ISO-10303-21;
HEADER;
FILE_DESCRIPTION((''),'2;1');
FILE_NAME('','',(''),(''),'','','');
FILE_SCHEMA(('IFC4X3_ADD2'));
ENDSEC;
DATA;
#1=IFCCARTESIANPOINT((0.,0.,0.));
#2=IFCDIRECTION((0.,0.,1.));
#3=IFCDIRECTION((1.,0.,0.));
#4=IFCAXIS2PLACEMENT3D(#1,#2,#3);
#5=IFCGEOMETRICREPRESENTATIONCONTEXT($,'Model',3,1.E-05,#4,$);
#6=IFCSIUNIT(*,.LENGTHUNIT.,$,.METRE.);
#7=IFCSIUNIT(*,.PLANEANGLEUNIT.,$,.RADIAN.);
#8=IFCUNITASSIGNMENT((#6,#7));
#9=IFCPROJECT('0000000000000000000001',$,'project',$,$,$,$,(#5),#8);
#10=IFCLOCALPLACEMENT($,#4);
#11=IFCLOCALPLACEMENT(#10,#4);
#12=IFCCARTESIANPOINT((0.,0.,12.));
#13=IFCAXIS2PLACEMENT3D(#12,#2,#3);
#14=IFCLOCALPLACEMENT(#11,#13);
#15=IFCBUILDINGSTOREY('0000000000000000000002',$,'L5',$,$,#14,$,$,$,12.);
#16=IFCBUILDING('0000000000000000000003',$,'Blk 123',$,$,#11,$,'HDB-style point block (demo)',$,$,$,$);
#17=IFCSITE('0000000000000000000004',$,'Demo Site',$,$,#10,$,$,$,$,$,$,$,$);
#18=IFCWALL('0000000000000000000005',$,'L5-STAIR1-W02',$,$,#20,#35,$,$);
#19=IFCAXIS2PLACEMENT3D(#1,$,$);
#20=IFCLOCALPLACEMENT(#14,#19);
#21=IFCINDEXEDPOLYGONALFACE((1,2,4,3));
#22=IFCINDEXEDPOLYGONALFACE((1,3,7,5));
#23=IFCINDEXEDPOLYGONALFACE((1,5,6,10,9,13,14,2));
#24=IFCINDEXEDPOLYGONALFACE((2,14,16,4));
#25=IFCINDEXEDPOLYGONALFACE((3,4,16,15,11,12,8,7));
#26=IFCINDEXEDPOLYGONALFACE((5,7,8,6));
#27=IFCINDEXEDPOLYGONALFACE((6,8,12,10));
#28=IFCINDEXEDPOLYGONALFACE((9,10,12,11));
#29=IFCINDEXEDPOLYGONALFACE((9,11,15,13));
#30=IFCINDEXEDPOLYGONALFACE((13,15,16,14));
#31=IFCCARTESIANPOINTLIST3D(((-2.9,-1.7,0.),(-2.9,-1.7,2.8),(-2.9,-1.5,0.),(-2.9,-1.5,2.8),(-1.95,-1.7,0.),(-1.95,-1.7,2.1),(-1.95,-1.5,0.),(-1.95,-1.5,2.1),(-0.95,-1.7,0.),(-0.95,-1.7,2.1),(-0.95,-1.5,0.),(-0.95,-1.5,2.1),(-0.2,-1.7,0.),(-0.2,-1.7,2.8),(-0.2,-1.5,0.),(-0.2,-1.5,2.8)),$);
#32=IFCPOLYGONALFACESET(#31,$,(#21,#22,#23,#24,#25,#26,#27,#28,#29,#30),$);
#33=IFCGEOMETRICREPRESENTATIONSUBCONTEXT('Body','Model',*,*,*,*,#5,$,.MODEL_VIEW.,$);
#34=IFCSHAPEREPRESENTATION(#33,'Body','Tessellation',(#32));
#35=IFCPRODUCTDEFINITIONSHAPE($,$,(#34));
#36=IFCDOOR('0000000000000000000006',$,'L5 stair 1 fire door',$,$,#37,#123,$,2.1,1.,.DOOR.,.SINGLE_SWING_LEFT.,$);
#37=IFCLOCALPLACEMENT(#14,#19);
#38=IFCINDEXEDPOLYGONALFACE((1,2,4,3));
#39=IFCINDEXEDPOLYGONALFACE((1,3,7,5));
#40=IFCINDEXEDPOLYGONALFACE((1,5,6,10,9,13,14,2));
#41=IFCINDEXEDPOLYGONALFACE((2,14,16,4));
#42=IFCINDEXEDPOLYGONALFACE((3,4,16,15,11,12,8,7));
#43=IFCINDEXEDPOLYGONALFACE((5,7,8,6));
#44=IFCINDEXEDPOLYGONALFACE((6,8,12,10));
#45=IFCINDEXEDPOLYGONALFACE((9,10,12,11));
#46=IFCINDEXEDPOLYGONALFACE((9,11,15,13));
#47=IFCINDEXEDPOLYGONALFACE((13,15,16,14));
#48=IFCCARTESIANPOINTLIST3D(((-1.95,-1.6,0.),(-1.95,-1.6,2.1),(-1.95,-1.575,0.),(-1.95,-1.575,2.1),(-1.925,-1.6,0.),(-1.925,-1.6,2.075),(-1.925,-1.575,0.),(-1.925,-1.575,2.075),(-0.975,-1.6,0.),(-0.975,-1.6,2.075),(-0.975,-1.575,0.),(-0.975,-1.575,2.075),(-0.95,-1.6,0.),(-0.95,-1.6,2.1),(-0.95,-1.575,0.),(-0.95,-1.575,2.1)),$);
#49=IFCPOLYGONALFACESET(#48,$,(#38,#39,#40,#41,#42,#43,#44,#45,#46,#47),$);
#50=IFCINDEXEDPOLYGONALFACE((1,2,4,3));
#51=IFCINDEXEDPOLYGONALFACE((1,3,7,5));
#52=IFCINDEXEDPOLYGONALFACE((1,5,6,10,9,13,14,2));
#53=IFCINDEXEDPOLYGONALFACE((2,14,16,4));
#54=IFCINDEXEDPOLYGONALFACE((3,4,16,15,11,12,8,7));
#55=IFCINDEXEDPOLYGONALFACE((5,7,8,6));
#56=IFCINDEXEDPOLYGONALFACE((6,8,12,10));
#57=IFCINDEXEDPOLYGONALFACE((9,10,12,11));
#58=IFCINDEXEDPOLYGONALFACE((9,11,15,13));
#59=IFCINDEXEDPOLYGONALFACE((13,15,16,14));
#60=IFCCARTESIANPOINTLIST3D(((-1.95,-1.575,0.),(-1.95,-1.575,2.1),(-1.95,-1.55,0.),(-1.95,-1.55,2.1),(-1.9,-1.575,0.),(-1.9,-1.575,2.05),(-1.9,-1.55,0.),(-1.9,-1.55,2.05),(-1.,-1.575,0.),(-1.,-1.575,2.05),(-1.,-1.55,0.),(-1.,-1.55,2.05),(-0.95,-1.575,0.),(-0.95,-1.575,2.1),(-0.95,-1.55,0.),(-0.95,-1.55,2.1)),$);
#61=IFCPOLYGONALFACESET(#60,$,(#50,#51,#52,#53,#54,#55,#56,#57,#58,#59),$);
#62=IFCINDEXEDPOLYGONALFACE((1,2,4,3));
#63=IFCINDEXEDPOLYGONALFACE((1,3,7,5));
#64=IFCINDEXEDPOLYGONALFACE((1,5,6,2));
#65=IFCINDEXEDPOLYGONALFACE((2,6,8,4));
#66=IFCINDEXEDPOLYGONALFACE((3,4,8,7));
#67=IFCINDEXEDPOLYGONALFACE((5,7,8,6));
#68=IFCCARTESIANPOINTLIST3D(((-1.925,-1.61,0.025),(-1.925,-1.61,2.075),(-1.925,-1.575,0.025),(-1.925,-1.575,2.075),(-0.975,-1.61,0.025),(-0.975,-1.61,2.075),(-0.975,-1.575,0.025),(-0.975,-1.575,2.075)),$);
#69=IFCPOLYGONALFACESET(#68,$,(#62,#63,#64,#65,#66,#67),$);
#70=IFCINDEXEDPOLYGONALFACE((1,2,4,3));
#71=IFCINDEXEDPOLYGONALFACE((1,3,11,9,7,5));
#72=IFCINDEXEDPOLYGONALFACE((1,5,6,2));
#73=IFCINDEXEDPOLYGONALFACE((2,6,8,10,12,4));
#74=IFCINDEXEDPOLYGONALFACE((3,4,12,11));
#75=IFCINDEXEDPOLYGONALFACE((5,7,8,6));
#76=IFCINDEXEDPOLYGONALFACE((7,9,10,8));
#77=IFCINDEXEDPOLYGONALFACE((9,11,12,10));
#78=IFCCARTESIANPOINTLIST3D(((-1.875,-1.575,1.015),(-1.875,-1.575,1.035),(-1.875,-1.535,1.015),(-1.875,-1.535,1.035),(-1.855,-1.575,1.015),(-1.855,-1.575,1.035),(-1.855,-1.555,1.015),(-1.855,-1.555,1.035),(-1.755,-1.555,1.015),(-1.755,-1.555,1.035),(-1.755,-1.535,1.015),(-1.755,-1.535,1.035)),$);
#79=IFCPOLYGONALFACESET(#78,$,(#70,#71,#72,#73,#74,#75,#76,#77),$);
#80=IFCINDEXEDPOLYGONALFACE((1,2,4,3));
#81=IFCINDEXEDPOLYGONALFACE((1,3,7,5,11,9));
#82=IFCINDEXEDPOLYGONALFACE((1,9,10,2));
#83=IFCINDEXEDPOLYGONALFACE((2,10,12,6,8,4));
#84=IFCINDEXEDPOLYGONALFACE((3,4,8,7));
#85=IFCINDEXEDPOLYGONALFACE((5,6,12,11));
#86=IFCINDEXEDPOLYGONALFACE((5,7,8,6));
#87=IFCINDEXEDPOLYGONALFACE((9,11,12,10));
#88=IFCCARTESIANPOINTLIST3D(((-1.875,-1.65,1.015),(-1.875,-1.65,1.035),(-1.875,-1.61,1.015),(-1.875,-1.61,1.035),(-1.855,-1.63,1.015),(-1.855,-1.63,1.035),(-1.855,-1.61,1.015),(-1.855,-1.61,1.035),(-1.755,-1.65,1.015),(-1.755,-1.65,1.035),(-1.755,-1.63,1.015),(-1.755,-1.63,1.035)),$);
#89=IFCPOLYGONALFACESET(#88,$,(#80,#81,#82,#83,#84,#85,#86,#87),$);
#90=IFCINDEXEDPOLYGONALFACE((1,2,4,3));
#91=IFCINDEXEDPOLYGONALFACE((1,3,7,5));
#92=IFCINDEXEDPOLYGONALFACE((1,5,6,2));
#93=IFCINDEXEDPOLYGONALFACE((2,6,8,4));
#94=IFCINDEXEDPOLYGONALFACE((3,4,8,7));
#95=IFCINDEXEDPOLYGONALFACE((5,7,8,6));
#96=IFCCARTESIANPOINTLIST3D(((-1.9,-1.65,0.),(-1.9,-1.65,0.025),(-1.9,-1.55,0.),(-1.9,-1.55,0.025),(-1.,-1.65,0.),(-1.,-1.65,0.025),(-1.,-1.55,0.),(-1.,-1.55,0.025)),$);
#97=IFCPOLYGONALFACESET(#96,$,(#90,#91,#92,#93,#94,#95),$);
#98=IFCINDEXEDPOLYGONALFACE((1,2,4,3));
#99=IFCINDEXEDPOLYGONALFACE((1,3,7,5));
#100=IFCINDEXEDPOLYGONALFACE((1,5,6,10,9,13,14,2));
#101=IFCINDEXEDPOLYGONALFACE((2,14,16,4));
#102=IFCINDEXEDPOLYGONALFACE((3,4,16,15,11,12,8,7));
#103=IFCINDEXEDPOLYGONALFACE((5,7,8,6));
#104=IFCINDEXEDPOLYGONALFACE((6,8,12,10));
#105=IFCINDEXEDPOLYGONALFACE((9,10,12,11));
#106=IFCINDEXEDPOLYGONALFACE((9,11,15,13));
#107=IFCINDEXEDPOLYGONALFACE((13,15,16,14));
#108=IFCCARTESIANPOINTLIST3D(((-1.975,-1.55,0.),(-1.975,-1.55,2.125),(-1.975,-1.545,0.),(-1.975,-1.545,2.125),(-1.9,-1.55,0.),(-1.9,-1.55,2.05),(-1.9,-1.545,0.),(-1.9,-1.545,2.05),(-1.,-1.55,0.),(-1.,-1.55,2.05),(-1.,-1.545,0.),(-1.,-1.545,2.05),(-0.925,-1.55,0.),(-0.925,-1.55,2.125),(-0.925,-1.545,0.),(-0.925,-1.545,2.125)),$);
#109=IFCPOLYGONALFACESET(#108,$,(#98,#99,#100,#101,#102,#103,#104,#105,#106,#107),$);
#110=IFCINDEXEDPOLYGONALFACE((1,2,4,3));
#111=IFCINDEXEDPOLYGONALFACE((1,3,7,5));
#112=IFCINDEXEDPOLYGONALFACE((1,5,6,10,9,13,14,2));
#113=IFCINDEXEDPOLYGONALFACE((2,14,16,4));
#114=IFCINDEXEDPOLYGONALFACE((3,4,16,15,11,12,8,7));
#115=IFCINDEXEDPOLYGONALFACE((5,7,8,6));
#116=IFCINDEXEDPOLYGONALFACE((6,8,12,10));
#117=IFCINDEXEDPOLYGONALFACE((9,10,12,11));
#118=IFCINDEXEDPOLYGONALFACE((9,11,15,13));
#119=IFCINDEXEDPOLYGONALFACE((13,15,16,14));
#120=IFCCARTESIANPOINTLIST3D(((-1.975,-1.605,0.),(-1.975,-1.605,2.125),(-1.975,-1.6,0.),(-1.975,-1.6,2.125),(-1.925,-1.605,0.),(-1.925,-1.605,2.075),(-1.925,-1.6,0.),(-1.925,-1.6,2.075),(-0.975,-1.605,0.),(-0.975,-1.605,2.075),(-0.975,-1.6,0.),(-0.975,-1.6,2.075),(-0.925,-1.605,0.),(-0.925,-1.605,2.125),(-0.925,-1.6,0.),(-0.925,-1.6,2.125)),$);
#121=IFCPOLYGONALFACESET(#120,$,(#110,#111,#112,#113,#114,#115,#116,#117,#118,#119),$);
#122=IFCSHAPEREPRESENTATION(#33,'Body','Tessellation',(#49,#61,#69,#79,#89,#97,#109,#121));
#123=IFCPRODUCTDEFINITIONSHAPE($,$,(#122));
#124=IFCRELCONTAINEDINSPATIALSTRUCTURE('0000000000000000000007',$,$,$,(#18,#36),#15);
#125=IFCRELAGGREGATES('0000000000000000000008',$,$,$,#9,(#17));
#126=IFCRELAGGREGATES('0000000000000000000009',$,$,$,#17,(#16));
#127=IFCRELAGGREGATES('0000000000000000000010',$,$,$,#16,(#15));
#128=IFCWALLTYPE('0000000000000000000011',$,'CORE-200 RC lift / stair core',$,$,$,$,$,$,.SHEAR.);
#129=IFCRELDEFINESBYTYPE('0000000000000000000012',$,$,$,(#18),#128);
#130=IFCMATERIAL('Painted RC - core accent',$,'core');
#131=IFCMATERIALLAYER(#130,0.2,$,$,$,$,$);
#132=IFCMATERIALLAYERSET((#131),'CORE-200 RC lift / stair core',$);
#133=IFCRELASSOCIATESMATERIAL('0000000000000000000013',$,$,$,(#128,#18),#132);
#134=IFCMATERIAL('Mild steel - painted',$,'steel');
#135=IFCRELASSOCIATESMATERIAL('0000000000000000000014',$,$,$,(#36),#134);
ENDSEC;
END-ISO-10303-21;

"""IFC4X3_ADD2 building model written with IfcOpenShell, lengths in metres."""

from ifc_helpers import new_model, si_unit, frame, origin_with_axes, place, context, subcontext, project, spatial, line, indexed_curve, outline, extrude, material, layer, layer_set, layer_usage, type_object, element, fill, save


model = new_model("IFC4X3_ADD2")

# Units and contexts
model_context = context("Model", 3, precision=1e-05, world=origin_with_axes())
body_context = subcontext(model_context, "Body", "Model", "MODEL_VIEW")
ifc_project = project(units=[si_unit("LENGTHUNIT", "METRE"), si_unit("PLANEANGLEUNIT", "RADIAN")], contexts=[model_context])

# Site, building, storey
site_placement = place(None, origin_with_axes())
site = spatial("IfcSite", under=ifc_project, at=site_placement, Name="Demo Site")
building_placement = place(site_placement, origin_with_axes())
building = spatial("IfcBuilding", under=site, at=building_placement, Name="Blk 123", LongName="HDB-style point block (demo)")
storey_placement = place(building_placement, frame((0.0, 0.0, 12.0), z_axis=(0.0, 0.0, 1.0), x_axis=(1.0, 0.0, 0.0)))
storey = spatial("IfcBuildingStorey", under=building, at=storey_placement, Name="L5", Elevation=12.0)

# Shared definitions
ifc_material_1 = material(Name="Painted RC - core accent", Category="core")
ifc_layer_1 = layer(ifc_material_1, 0.2)
ifc_layer_set_1 = layer_set([ifc_layer_1], Name="CORE-200 RC lift / stair core")
ifc_layer_usage_1 = layer_usage(ifc_layer_set_1, "AXIS2", "POSITIVE", 0.0)
wall_type_1 = type_object("IfcWallType", Name="CORE-200 RC lift / stair core", PredefinedType="SHEAR", material=ifc_layer_set_1)

# Wall, opening, door
wall_1_placement = place(storey_placement, frame((-0.2, -1.5, 0.0), z_axis=(0.0, 0.0, 1.0), x_axis=(-1.0, 0.0, 0.0)))
wall_1 = element("IfcWall", 1, at=wall_1_placement, inside=storey, type_object=wall_type_1, material=ifc_layer_usage_1, Name="L5-STAIR1-W02", context=body_context, shape_type="SweptSolid", body=[
    extrude(outline(indexed_curve([(0.0, 0.0), (0.0, 0.2), (2.7, 0.2), (2.7, 0.0), (0.0, 0.0)], self_intersect=False)), origin_with_axes(), (0.0, 0.0, 1.0), 2.8),
])
opening_1_placement = place(wall_1_placement, frame((0.75, -0.1, 0.0), z_axis=(0.0, 0.0, 1.0), x_axis=(1.0, 0.0, 0.0)))
opening_1 = element("IfcOpeningElement", 2, at=opening_1_placement, cuts=wall_1, context=body_context, shape_type="SweptSolid", body=[
    extrude(outline(indexed_curve([(0.0, 0.0), (0.0, 0.4), (1.0, 0.4), (1.0, 0.0), (0.0, 0.0)], self_intersect=False)), origin_with_axes(), (0.0, 0.0, 1.0), 2.1),
])
ifc_material_2 = material(Name="Mild steel - painted", Category="steel")
door_1_placement = place(opening_1_placement, frame((0.0, 0.15, 0.0), z_axis=(0.0, 0.0, 1.0), x_axis=(1.0, 0.0, 0.0)))
door_1 = element("IfcDoor", 3, at=door_1_placement, inside=storey, material=ifc_material_2, Name="L5 stair 1 fire door", OperationType="SINGLE_SWING_LEFT", OverallHeight=2.1, OverallWidth=1.0, PredefinedType="DOOR", context=body_context, shape_type="SweptSolid", body=[
    extrude(outline(indexed_curve([(0.0, 0.0), (0.0, 2.1), (1.0, 2.1), (1.0, 0.0), (0.975, 0.0), (0.975, 2.075), (0.025, 2.075), (0.025, 0.0)], segments=[line(1, 2, 3, 4, 5, 6, 7, 8, 1)])), frame((0.0, 0.025, 0.0), z_axis=(0.0, -1.0, 0.0), x_axis=(1.0, 0.0, 0.0)), (0.0, 0.0, -1.0), 0.025),
    extrude(outline(indexed_curve([(0.0, 0.0), (0.0, 2.1), (1.0, 2.1), (1.0, 0.0), (0.95, 0.0), (0.95, 2.05), (0.05, 2.05), (0.05, 0.0)], segments=[line(1, 2, 3, 4, 5, 6, 7, 8, 1)])), frame((0.0, 0.0, 0.0), z_axis=(0.0, -1.0, 0.0), x_axis=(1.0, 0.0, 0.0)), (0.0, 0.0, -1.0), 0.025),
    extrude(outline(indexed_curve([(0.0, 0.0), (0.95, 0.0), (0.95, 0.035), (0.0, 0.035)], segments=[line(1, 2, 3, 4, 1)])), frame((0.025, 0.025, 0.025), z_axis=(0.0, 0.0, 1.0), x_axis=(1.0, 0.0, 0.0)), (0.0, 0.0, 1.0), 2.05),
    extrude(outline(indexed_curve([(0.0, 0.0), (0.0, -0.04), (-0.12, -0.04), (-0.12, -0.02), (-0.02, -0.02), (-0.02, 0.0)], segments=[line(1, 2, 3, 4, 5, 6, 1)])), frame((0.925, 0.025, 1.015), z_axis=(0.0, 0.0, 1.0), x_axis=(1.0, 0.0, 0.0)), (0.0, 0.0, 1.0), 0.02),
    extrude(outline(indexed_curve([(0.0, 0.0), (0.0, 0.04), (-0.12, 0.04), (-0.12, 0.02), (-0.02, 0.02), (-0.02, 0.0)], segments=[line(1, 2, 3, 4, 5, 6, 1)])), frame((0.925, 0.06, 1.015), z_axis=(0.0, 0.0, 1.0), x_axis=(1.0, 0.0, 0.0)), (0.0, 0.0, 1.0), 0.02),
    extrude(outline(indexed_curve([(0.0, 0.0), (0.9, 0.0), (0.9, 0.1), (0.0, 0.1)], segments=[line(1, 2, 3, 4, 1)])), frame((0.05, 0.0, 0.0), z_axis=(0.0, 0.0, 1.0), x_axis=(1.0, 0.0, 0.0)), (0.0, 0.0, 1.0), 0.025),
    extrude(outline(indexed_curve([(0.0, 0.0), (0.0, 2.125), (1.05, 2.125), (1.05, 0.0), (0.975, 0.0), (0.975, 2.05), (0.075, 2.05), (0.075, 0.0)], segments=[line(1, 2, 3, 4, 5, 6, 7, 8, 1)])), frame((-0.025, -0.005, 0.0), z_axis=(0.0, -1.0, 0.0), x_axis=(1.0, 0.0, 0.0)), (0.0, 0.0, -1.0), 0.005),
    extrude(outline(indexed_curve([(0.0, 0.0), (0.0, 2.125), (1.05, 2.125), (1.05, 0.0), (1.0, 0.0), (1.0, 2.075), (0.05, 2.075), (0.05, 0.0)], segments=[line(1, 2, 3, 4, 5, 6, 7, 8, 1)])), frame((-0.025, 0.05, 0.0), z_axis=(0.0, -1.0, 0.0), x_axis=(1.0, 0.0, 0.0)), (0.0, 0.0, -1.0), 0.005),
])
fill(opening_1, door_1)

save(model, "model.ifc")
